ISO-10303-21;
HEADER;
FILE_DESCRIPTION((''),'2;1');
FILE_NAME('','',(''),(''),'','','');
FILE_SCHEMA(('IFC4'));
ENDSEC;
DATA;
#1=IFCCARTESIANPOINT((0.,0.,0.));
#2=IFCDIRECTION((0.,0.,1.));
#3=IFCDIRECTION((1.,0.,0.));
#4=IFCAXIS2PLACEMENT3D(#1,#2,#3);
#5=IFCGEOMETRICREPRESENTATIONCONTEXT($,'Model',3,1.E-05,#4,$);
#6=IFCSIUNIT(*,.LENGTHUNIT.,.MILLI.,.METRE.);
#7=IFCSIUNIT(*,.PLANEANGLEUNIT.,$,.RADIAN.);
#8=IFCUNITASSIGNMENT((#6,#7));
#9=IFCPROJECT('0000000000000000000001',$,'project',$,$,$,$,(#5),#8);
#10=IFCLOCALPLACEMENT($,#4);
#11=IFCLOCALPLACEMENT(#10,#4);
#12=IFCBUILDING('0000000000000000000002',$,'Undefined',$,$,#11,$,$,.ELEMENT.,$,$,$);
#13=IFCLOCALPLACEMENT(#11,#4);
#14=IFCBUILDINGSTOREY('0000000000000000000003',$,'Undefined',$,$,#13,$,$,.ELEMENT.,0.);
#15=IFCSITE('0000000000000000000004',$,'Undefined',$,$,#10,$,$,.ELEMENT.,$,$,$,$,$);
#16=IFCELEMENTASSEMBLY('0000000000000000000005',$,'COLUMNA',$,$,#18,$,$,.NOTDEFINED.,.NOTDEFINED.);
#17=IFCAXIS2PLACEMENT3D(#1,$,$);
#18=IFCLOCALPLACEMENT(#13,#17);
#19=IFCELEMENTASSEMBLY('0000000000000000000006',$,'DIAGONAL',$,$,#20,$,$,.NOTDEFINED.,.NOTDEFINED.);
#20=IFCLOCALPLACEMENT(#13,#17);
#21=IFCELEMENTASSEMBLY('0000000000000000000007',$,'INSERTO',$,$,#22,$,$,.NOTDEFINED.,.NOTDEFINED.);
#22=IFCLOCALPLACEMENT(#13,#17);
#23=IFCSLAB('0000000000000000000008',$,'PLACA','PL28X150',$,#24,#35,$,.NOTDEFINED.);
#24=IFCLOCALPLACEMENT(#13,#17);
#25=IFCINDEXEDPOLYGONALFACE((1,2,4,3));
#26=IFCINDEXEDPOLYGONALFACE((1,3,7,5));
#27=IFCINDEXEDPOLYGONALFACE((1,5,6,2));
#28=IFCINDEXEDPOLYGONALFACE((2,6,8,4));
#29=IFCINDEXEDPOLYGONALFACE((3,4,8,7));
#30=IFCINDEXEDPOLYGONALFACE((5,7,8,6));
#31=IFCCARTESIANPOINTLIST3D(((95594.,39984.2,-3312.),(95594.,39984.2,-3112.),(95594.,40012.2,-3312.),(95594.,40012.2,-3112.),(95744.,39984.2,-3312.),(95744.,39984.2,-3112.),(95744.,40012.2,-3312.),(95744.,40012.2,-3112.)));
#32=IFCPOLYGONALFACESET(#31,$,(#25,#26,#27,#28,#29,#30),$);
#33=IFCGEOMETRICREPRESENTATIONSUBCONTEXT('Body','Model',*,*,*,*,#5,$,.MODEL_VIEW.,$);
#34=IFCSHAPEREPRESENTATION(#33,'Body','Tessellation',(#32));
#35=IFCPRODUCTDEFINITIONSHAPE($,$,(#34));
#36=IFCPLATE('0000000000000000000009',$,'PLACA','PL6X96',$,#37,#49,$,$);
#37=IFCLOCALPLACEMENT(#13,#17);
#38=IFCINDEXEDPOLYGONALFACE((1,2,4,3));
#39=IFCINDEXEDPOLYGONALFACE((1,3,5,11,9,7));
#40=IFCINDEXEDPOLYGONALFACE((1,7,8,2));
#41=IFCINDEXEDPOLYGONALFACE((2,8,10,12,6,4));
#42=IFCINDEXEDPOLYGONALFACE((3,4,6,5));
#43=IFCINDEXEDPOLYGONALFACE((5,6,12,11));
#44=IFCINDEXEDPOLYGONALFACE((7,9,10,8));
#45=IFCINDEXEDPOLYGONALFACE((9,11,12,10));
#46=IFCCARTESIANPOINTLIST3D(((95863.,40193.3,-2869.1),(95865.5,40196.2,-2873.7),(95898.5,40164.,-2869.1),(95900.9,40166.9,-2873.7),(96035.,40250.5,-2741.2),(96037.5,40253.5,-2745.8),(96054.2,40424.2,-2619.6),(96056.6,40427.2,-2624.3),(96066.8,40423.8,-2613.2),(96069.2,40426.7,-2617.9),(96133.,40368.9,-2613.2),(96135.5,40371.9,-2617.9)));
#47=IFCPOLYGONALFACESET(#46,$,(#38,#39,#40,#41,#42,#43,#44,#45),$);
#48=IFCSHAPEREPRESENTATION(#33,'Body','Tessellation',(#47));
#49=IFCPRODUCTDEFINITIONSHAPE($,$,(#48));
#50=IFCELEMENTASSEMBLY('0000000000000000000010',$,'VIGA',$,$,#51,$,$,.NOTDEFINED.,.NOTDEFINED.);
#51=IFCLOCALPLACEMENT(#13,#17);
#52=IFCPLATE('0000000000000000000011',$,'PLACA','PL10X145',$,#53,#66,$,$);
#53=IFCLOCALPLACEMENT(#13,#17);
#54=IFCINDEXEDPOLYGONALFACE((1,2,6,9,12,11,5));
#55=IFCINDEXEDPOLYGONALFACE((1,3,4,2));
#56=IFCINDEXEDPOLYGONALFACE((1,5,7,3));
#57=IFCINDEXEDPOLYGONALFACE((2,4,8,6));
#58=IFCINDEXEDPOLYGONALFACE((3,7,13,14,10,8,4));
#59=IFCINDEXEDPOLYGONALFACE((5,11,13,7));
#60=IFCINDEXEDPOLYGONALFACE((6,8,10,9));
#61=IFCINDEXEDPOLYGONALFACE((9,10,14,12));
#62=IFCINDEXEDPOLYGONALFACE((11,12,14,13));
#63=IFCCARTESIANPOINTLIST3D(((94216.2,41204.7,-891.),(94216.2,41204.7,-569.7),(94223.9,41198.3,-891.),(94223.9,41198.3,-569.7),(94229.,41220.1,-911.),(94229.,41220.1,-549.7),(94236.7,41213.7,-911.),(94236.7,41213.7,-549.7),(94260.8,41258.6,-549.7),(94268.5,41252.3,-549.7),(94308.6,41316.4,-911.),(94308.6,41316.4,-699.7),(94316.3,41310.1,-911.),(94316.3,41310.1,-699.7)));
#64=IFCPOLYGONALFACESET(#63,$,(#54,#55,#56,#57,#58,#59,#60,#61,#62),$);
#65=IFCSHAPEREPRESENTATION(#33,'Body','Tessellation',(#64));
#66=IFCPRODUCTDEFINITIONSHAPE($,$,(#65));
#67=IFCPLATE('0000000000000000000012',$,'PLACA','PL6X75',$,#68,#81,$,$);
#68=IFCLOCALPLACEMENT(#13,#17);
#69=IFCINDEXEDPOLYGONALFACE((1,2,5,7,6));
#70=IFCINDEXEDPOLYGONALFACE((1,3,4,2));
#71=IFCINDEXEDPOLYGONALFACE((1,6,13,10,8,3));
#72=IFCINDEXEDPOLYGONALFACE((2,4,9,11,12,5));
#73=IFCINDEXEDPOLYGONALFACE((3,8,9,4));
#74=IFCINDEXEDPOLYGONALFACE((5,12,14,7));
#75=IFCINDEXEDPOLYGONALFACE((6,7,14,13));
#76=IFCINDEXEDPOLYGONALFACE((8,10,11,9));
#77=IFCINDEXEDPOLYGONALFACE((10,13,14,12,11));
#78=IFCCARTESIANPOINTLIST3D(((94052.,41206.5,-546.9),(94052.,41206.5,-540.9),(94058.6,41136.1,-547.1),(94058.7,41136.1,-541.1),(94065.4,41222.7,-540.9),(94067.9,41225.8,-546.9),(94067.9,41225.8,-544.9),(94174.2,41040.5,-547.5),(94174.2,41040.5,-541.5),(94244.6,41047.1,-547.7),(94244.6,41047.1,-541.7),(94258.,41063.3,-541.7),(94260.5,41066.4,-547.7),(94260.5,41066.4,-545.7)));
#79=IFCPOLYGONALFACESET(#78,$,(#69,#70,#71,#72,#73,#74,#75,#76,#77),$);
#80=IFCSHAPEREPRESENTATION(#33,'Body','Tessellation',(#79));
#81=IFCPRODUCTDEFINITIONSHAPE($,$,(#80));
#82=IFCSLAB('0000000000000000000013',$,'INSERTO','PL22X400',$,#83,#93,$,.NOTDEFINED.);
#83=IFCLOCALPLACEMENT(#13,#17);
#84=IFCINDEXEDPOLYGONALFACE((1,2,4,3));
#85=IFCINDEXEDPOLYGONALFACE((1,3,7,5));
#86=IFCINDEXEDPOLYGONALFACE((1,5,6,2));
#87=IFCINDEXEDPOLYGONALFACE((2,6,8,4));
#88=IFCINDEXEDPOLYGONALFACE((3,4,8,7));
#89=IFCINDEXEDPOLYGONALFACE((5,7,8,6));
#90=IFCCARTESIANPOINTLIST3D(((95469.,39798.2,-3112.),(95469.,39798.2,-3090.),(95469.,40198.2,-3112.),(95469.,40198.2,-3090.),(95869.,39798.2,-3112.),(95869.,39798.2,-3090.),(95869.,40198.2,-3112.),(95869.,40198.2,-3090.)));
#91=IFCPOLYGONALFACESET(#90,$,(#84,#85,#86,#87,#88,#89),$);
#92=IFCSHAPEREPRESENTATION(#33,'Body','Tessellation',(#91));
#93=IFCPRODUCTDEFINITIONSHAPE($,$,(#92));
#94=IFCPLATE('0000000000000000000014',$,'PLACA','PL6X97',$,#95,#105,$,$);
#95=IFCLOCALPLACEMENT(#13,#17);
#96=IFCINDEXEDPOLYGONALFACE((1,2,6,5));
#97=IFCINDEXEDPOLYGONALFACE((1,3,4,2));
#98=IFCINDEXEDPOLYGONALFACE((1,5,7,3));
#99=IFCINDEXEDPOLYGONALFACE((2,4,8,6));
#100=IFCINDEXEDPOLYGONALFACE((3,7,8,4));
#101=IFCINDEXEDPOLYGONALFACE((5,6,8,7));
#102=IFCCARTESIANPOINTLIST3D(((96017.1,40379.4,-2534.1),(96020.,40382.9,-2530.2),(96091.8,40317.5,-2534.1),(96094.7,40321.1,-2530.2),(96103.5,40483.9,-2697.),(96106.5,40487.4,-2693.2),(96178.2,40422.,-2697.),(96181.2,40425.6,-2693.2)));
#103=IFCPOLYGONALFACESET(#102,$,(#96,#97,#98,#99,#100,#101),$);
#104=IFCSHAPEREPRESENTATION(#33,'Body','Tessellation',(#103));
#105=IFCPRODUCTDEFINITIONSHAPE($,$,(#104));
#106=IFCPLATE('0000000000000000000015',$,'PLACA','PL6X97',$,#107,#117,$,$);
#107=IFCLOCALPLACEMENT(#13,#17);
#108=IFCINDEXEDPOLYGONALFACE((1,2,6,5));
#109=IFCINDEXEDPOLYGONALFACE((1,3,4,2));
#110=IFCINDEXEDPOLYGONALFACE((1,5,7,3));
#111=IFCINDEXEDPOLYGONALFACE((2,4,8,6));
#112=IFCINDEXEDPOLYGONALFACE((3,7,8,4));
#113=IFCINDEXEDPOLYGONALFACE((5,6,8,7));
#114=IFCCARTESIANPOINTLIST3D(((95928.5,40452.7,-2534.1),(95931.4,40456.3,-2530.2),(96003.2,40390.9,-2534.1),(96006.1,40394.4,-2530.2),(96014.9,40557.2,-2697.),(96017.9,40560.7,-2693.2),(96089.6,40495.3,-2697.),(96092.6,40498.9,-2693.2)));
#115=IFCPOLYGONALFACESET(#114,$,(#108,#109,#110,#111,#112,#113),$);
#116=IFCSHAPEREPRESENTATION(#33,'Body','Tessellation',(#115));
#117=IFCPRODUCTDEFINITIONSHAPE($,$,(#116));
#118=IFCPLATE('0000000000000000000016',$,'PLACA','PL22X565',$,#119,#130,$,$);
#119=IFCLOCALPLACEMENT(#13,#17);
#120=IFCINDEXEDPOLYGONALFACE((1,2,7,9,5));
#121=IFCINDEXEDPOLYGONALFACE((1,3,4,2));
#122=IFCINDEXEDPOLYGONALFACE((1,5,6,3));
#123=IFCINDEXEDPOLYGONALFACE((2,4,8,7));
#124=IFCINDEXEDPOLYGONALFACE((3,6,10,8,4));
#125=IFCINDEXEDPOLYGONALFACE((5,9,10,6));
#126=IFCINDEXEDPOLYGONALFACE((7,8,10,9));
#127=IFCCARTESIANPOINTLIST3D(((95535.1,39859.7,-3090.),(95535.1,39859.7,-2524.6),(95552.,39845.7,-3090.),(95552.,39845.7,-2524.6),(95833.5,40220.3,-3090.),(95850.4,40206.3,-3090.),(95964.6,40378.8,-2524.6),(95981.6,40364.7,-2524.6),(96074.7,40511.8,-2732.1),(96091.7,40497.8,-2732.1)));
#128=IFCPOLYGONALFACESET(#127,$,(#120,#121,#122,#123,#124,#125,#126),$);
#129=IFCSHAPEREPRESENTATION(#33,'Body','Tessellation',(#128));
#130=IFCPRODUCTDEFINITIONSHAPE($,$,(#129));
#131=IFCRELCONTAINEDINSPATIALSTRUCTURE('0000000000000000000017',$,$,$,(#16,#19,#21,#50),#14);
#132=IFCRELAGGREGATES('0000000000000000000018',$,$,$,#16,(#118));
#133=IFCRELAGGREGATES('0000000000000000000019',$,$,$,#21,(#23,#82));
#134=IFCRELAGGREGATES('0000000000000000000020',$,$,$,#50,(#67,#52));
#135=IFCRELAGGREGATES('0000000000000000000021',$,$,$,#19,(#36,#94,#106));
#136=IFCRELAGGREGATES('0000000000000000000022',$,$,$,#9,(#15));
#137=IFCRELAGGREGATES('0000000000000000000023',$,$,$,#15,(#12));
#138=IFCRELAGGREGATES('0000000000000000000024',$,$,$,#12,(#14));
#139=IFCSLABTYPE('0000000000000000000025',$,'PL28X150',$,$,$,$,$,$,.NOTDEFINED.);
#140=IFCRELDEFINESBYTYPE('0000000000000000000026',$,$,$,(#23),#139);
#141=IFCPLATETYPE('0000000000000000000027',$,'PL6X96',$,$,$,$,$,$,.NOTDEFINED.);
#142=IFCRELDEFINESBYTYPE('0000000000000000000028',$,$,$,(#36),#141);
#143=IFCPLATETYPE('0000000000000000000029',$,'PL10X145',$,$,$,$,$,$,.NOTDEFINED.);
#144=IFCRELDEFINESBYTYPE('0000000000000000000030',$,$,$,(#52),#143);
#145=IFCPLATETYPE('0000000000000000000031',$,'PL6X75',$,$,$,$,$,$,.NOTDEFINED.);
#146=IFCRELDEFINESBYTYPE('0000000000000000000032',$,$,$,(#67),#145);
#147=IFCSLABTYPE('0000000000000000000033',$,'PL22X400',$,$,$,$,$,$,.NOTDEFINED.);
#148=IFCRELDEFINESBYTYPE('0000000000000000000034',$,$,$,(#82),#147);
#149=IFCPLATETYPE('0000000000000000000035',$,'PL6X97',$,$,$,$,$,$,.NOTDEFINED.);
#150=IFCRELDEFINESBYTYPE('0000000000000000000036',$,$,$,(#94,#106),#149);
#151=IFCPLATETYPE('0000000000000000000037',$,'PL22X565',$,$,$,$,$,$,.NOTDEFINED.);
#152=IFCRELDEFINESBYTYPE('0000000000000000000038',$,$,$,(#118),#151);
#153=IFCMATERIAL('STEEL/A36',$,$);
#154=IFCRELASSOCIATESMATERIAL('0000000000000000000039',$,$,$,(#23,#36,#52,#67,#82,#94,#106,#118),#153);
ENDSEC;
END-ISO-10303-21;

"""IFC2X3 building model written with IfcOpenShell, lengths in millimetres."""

from ifc_helpers import new_model, si_unit, frame, origin_with_axes, place, context, subcontext, project, spatial, polyline, outline, extrude, boolean, material, type_object, element, aggregate, save


model = new_model("IFC2X3")

# Units and contexts
model_context = context("Model", 3, precision=1e-05, world=origin_with_axes())
body_context = subcontext(model_context, "Body", "Model", "MODEL_VIEW")
ifc_project = project(units=[si_unit("LENGTHUNIT", "METRE", prefix="MILLI"), si_unit("PLANEANGLEUNIT", "RADIAN")], contexts=[model_context])

# Site, building, storey
site_placement = place(None, origin_with_axes())
site = spatial("IfcSite", under=ifc_project, at=site_placement, Name="Undefined", CompositionType="ELEMENT")
building_placement = place(site_placement, origin_with_axes())
building = spatial("IfcBuilding", under=site, at=building_placement, Name="Undefined", CompositionType="ELEMENT")
storey_placement = place(building_placement, origin_with_axes())
storey = spatial("IfcBuildingStorey", under=building, at=storey_placement, Name="Undefined", CompositionType="ELEMENT", Elevation=0.0)

# Element assembly
assembly_1_placement = place(storey_placement, origin_with_axes())
assembly_1 = element("IfcElementAssembly", 1, at=assembly_1_placement, inside=storey, Name="COLUMNA", AssemblyPlace="NOTDEFINED", PredefinedType="NOTDEFINED")
ifc_material_1 = material(Name="STEEL/A36")

# Element assembly
assembly_2_placement = place(storey_placement, origin_with_axes())
assembly_2 = element("IfcElementAssembly", 2, at=assembly_2_placement, inside=storey, Name="DIAGONAL", AssemblyPlace="NOTDEFINED", PredefinedType="NOTDEFINED")

# Element assembly, slab
assembly_3_placement = place(storey_placement, origin_with_axes())
assembly_3 = element("IfcElementAssembly", 3, at=assembly_3_placement, inside=storey, Name="INSERTO", AssemblyPlace="NOTDEFINED", PredefinedType="NOTDEFINED")
slab_type_1 = type_object("IfcSlabType", Name="PL28X150", PredefinedType="NOTDEFINED")
slab_1_placement = place(assembly_3_placement, frame((95594.0, 39998.2, -3112.0), z_axis=(0.0, 1.0, 0.0), x_axis=(1.0, 0.0, 0.0)))
slab_1 = element("IfcSlab", 4, at=slab_1_placement, type_object=slab_type_1, material=ifc_material_1, Name="PLACA", Description="PL28X150", PredefinedType="NOTDEFINED", context=body_context, shape_type="SweptSolid", body=[
    extrude(outline(polyline([(0.0, 0.0), (150.0, 0.0), (150.0, 200.0), (0.0, 200.0), (0.0, 0.0)])), frame((0.0, 0.0, -14.0), z_axis=(0.0, 0.0, 1.0), x_axis=(1.0, 0.0, 0.0)), (0.0, 0.0, 1.0), 28.0),
])

# Plate
plate_type_1 = type_object("IfcPlateType", Name="PL6X96", PredefinedType="NOTDEFINED")
plate_1_placement = place(assembly_2_placement, frame((96134.2, 40370.4, -2615.5), z_axis=(-0.407839, -0.492816, 0.768635), x_axis=(-0.770401, 0.63756, 0.0)))
plate_1 = element("IfcPlate", 5, at=plate_1_placement, type_object=plate_type_1, material=ifc_material_1, Name="PLACA", Description="PL6X96", context=body_context, shape_type="SweptSolid", body=[
    extrude(outline(polyline([(0.0, 0.0), (86.0, 0.0), (96.0, 10.0), (96.0, 400.0), (50.0, 400.0), (0.0, 200.0), (0.0, 0.0)])), frame((0.0, 0.0, -3.0), z_axis=(0.0, 0.0, 1.0), x_axis=(1.0, 0.0, 0.0)), (0.0, 0.0, 1.0), 6.0),
])

# Element assembly, plates
assembly_4_placement = place(storey_placement, origin_with_axes())
assembly_4 = element("IfcElementAssembly", 6, at=assembly_4_placement, inside=storey, Name="VIGA", AssemblyPlace="NOTDEFINED", PredefinedType="NOTDEFINED")
plate_type_2 = type_object("IfcPlateType", Name="PL10X145", PredefinedType="NOTDEFINED")
plate_2_placement = place(assembly_4_placement, frame((94220.1, 41201.5, -911.0), z_axis=(0.770506, -0.637433, 0.0), x_axis=(0.637432, 0.770506, 0.0)))
plate_2 = element("IfcPlate", 7, at=plate_2_placement, type_object=plate_type_2, material=ifc_material_1, Name="PLACA", Description="PL10X145", context=body_context, shape_type="SweptSolid", body=[
    extrude(outline(polyline([(0.0, 20.0), (20.0, 0.0), (145.0, 0.0), (145.0, 211.4), (70.0, 361.4), (20.0, 361.4), (0.0, 341.4), (0.0, 20.0)])), frame((0.0, 0.0, -5.0), z_axis=(0.0, 0.0, 1.0), x_axis=(1.0, 0.0, 0.0)), (0.0, 0.0, 1.0), 10.0),
])
plate_type_3 = type_object("IfcPlateType", Name="PL6X75", PredefinedType="NOTDEFINED")
plate_3_placement = place(assembly_4_placement, frame((94067.9, 41225.8, -543.9), z_axis=(-0.002297, 0.001901, -0.999996), x_axis=(0.770396, -0.637559, -0.002981)))
plate_3 = element("IfcPlate", 8, at=plate_3_placement, type_object=plate_type_3, material=ifc_material_1, Name="PLACA", Description="PL6X75", context=body_context, shape_type="CSG", body=[
    boolean("DIFFERENCE", extrude(outline(polyline([(0.0, 0.0), (250.0, 0.0), (250.0, 25.0), (200.0, 75.0), (50.0, 75.0), (0.0, 25.0), (0.0, 0.0)])), frame((0.0, 0.0, -3.0), z_axis=(0.0, 0.0, 1.0), x_axis=(1.0, 0.0, 0.0)), (0.0, 0.0, 1.0), 6.0), extrude(outline(polyline([(0.0, 0.0), (4.0, 0.0), (4.0, 4.0), (0.0, 0.0)])), frame((255.0, 4.0, -3.0), z_axis=(-1.0, 0.0, 0.0), x_axis=(0.0, -1.0, 0.0)), (0.0, 0.0, 1.0), 260.0)),
])

# Slab
slab_type_2 = type_object("IfcSlabType", Name="PL22X400", PredefinedType="NOTDEFINED")
slab_2_placement = place(assembly_3_placement, frame((95469.0, 39798.2, -3101.0), z_axis=(0.0, 0.0, 1.0), x_axis=(1.0, 0.0, 0.0)))
slab_2 = element("IfcSlab", 9, at=slab_2_placement, type_object=slab_type_2, material=ifc_material_1, Name="INSERTO", Description="PL22X400", PredefinedType="NOTDEFINED", context=body_context, shape_type="SweptSolid", body=[
    extrude(outline(polyline([(0.0, 0.0), (400.0, 0.0), (400.0, 400.0), (0.0, 400.0), (0.0, 0.0)])), frame((0.0, 0.0, -11.0), z_axis=(0.0, 0.0, 1.0), x_axis=(1.0, 0.0, 0.0)), (0.0, 0.0, 1.0), 22.0),
])

# Plates
plate_type_4 = type_object("IfcPlateType", Name="PL6X97", PredefinedType="NOTDEFINED")
plate_4_placement = place(assembly_2_placement, frame((96179.7, 40423.8, -2695.1), z_axis=(0.490051, 0.592157, 0.639687), x_axis=(-0.770401, 0.63756, 0.0)))
plate_4 = element("IfcPlate", 10, at=plate_4_placement, type_object=plate_type_4, material=ifc_material_1, Name="PLACA", Description="PL6X97", context=body_context, shape_type="SweptSolid", body=[
    extrude(outline(polyline([(0.0, 0.0), (97.0, 0.0), (97.0, 212.0), (0.0, 212.0), (0.0, 0.0)])), frame((0.0, 0.0, -3.0), z_axis=(0.0, 0.0, 1.0), x_axis=(1.0, 0.0, 0.0)), (0.0, 0.0, 1.0), 6.0),
])
plate_5_placement = place(assembly_2_placement, frame((96091.1, 40497.1, -2695.1), z_axis=(0.490051, 0.592157, 0.639687), x_axis=(-0.770401, 0.63756, 0.0)))
plate_5 = element("IfcPlate", 11, at=plate_5_placement, type_object=plate_type_4, material=ifc_material_1, Name="PLACA", Description="PL6X97", context=body_context, shape_type="SweptSolid", body=[
    extrude(outline(polyline([(0.0, 0.0), (97.0, 0.0), (97.0, 212.0), (0.0, 212.0), (0.0, 0.0)])), frame((0.0, 0.0, -3.0), z_axis=(0.0, 0.0, 1.0), x_axis=(1.0, 0.0, 0.0)), (0.0, 0.0, 1.0), 6.0),
])
plate_type_5 = type_object("IfcPlateType", Name="PL22X565", PredefinedType="NOTDEFINED")
plate_6_placement = place(assembly_1_placement, frame((95543.5, 39852.7, -2524.6), z_axis=(0.770401, -0.63756, 0.0), x_axis=(0.0, 0.0, -1.0)))
plate_6 = element("IfcPlate", 12, at=plate_6_placement, type_object=plate_type_5, material=ifc_material_1, Name="PLACA", Description="PL22X565", context=body_context, shape_type="SweptSolid", body=[
    extrude(outline(polyline([(0.0, 0.0), (565.4, 0.0), (565.4, 468.0), (207.5, 846.4), (0.0, 673.7), (0.0, 0.0)])), frame((0.0, 0.0, -11.0), z_axis=(0.0, 0.0, 1.0), x_axis=(1.0, 0.0, 0.0)), (0.0, 0.0, 1.0), 22.0),
])
aggregate(assembly_1, [plate_6])

aggregate(assembly_3, [slab_1, slab_2])
aggregate(assembly_4, [plate_3, plate_2])

aggregate(assembly_2, [plate_1, plate_4, plate_5])

save(model, "model.ifc")
